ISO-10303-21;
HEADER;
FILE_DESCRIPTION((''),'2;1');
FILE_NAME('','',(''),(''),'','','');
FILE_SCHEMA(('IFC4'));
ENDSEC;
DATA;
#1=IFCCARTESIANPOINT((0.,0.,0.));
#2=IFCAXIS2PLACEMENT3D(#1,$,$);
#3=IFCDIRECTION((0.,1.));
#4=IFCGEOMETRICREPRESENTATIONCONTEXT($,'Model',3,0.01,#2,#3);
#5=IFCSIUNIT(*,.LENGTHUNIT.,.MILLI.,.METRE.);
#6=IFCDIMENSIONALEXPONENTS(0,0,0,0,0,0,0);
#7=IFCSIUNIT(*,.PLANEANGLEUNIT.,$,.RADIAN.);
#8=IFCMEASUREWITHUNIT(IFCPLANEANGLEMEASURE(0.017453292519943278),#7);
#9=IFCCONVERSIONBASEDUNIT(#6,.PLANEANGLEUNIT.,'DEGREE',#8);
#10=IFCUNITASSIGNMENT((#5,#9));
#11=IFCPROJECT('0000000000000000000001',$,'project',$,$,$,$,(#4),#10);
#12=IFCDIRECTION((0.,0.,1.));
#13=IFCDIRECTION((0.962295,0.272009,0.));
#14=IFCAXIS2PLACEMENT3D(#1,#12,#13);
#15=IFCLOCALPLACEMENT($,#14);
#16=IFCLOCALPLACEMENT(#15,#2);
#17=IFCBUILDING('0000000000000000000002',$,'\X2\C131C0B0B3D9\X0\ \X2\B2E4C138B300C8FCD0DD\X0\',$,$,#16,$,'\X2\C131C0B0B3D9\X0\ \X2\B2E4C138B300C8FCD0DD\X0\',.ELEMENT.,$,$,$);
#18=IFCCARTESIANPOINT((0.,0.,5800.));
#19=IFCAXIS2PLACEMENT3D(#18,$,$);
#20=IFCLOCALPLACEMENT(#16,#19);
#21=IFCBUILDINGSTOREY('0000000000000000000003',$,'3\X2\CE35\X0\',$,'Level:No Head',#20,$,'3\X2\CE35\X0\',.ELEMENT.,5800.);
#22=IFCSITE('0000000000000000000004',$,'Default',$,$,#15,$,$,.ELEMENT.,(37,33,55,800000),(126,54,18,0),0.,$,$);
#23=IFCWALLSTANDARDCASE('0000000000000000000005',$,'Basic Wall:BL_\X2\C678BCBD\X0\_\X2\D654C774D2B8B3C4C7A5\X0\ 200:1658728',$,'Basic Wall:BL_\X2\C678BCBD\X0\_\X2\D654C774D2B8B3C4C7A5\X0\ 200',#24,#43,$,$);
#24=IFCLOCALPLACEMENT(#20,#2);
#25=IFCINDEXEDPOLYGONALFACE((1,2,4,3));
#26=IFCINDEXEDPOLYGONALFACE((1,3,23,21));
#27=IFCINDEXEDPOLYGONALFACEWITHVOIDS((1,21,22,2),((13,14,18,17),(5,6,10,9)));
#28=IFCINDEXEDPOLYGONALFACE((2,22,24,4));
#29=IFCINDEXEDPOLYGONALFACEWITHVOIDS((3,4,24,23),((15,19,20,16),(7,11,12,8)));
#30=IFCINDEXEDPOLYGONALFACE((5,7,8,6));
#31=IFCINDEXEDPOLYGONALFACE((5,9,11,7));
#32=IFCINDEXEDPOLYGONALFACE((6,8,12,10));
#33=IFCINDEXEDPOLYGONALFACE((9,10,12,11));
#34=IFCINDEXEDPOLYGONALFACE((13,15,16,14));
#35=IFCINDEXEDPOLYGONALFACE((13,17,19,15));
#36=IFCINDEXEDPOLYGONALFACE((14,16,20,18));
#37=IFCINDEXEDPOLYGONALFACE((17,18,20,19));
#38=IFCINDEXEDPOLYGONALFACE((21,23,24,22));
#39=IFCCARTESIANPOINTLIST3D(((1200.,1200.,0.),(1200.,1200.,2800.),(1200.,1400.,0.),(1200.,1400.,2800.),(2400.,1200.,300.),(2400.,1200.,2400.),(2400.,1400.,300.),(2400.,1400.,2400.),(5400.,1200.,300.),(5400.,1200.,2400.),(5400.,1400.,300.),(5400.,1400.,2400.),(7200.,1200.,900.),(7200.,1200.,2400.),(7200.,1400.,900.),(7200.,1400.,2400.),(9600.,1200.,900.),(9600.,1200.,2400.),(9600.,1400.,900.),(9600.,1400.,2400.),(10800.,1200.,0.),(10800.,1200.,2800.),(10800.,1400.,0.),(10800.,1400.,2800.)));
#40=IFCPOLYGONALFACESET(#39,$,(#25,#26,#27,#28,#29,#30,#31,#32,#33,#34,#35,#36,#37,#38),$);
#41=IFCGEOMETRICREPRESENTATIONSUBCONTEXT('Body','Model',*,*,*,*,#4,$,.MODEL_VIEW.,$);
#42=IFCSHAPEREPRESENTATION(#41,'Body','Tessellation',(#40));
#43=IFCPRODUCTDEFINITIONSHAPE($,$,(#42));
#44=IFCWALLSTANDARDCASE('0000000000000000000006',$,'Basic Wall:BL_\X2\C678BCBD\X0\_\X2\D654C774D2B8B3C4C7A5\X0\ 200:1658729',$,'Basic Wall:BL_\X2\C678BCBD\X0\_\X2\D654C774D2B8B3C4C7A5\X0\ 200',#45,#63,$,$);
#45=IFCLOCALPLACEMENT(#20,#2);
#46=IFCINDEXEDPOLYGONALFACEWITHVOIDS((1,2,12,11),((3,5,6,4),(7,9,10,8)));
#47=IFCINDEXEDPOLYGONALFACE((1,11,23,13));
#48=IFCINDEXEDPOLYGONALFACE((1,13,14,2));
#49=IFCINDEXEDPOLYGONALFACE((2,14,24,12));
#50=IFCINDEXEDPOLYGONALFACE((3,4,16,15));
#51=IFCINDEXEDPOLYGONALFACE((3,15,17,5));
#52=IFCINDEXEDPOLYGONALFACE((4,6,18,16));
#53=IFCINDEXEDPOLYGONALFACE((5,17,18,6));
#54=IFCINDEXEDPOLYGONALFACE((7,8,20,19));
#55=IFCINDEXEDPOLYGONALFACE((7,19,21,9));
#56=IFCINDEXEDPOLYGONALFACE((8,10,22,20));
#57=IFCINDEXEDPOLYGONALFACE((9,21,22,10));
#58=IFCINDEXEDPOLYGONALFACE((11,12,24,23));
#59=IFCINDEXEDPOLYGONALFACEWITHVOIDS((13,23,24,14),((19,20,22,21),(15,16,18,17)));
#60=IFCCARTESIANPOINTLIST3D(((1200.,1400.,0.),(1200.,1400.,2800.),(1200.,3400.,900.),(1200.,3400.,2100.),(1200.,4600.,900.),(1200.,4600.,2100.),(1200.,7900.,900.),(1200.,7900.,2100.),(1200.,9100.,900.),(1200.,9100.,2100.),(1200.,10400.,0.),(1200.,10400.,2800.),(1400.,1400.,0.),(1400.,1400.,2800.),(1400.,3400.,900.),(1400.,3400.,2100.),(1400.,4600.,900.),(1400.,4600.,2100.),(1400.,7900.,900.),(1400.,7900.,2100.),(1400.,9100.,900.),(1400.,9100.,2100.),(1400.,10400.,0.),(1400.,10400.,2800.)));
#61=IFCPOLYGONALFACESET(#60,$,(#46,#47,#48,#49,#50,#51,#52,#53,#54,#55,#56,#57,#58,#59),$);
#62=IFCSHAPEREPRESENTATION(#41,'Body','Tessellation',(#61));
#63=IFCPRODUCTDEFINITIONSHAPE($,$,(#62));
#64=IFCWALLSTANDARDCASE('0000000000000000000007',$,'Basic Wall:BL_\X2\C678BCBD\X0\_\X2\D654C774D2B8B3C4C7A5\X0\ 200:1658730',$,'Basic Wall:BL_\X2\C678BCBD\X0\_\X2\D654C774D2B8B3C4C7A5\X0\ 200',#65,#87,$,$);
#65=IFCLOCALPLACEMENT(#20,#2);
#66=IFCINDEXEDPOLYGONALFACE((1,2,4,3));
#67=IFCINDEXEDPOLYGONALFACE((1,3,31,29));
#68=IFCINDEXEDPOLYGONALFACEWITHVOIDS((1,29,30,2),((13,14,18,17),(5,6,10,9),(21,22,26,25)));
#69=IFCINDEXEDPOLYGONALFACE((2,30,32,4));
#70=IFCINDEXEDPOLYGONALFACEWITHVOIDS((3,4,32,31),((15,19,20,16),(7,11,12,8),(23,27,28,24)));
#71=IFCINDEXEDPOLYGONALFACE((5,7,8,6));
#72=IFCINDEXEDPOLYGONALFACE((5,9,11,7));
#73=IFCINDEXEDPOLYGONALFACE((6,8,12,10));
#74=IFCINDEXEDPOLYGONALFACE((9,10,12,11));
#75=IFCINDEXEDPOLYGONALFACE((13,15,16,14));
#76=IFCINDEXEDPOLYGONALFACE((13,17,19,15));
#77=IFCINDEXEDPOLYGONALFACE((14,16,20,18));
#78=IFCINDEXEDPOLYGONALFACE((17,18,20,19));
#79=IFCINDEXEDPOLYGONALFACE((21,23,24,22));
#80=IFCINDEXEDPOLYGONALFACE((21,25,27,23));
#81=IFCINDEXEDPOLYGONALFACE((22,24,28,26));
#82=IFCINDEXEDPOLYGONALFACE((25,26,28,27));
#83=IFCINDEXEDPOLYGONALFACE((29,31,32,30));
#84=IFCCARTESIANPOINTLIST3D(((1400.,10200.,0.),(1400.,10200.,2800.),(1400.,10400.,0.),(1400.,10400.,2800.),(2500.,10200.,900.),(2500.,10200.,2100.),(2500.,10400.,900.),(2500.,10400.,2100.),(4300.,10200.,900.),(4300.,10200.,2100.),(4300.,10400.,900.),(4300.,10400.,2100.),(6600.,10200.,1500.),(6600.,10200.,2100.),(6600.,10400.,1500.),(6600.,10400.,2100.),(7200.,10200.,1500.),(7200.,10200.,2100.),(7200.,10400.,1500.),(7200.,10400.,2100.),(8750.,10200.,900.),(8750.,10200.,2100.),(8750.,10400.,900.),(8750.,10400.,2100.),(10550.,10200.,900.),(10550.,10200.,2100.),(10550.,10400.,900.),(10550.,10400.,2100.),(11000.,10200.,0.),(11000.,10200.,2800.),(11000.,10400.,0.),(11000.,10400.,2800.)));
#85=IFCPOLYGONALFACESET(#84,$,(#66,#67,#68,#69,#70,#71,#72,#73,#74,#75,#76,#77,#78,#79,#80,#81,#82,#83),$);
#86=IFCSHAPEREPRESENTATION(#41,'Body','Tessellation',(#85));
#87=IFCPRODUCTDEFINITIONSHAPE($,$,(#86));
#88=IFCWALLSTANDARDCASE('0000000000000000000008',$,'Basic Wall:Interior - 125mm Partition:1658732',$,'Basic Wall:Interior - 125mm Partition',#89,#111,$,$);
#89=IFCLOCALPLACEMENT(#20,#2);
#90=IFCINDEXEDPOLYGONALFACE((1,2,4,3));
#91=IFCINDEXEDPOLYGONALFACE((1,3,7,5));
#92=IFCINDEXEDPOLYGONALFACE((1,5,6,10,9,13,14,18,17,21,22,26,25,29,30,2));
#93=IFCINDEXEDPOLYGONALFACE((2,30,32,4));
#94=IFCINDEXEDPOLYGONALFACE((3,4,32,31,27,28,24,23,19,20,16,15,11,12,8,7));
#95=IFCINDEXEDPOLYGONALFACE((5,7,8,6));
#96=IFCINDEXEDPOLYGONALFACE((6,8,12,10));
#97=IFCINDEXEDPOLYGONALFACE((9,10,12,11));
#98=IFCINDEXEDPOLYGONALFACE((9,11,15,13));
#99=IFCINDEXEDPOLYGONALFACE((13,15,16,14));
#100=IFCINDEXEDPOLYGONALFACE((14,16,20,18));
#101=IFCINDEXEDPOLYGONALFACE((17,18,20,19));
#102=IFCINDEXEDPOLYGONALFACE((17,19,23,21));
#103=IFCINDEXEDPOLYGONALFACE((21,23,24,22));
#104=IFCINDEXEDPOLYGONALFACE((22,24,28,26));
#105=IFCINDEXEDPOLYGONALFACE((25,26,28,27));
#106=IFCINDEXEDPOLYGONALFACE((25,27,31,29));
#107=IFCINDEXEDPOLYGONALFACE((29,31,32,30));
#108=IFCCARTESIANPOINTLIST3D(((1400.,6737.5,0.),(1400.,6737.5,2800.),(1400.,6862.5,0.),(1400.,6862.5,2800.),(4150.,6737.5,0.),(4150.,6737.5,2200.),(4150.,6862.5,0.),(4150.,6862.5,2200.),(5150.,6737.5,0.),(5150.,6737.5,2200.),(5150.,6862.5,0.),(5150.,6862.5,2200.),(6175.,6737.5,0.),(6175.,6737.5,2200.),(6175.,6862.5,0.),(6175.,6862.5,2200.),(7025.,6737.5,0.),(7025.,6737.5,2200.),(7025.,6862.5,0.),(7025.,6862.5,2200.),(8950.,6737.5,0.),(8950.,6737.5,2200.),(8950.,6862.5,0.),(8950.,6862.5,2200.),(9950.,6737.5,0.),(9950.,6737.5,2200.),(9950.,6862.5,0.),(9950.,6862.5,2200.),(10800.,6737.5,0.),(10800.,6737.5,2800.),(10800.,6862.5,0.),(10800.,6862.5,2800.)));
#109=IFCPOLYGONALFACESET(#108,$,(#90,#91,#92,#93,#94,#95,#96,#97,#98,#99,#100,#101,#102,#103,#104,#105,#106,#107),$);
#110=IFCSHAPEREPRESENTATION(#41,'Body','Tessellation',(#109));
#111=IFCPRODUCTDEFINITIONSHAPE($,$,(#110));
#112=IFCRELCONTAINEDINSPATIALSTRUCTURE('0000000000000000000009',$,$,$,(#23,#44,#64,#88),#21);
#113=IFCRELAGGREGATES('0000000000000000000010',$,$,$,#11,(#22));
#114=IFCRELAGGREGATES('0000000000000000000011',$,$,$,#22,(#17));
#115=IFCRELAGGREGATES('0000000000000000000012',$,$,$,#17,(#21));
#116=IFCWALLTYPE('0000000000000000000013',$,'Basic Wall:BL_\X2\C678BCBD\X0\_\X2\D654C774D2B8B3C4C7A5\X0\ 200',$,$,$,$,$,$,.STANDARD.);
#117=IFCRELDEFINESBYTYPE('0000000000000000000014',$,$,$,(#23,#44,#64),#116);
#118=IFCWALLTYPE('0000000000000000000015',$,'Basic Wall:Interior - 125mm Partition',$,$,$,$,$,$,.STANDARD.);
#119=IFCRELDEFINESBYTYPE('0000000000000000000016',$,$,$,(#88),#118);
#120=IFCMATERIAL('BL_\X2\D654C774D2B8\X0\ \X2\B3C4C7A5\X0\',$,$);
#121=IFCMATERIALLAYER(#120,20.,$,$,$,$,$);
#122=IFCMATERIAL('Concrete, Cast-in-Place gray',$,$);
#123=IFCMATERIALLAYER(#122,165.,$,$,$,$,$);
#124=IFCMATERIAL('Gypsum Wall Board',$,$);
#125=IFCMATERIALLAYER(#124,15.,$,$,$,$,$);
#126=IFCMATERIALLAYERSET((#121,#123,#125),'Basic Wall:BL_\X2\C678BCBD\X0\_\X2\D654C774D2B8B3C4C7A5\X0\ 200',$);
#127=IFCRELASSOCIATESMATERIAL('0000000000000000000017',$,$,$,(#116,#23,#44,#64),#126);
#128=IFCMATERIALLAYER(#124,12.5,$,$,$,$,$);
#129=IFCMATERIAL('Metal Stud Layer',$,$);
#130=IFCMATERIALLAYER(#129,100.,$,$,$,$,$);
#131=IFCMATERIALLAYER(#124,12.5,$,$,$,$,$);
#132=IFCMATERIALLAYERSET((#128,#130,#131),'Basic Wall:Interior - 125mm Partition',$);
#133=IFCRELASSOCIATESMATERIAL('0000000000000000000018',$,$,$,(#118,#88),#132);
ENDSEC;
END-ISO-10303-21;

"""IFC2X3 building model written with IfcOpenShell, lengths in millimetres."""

from ifc_helpers import new_model, entity, si_unit, converted_unit, direction, frame, frame_2d, origin, place, context, subcontext, project, spatial, rectangle, extrude, material, layer, layer_set, layer_usage, type_object, element, save


model = new_model("IFC2X3")

# Units and contexts
model_context = context("Model", 3, precision=0.01, world=origin(), true_north=direction((0.0, 1.0)))
body_context = subcontext(model_context, "Body", "Model", "MODEL_VIEW")
ifc_project = project(units=[si_unit("LENGTHUNIT", "METRE", prefix="MILLI"), converted_unit("PLANEANGLEUNIT", "DEGREE", entity("IfcPlaneAngleMeasure", 0.017453292519943278), si_unit("PLANEANGLEUNIT", "RADIAN"), dimensions=[0, 0, 0, 0, 0, 0, 0])], contexts=[model_context])

# Site, building, storey
site_placement = place(None, frame((0.0, 0.0, 0.0), z_axis=(0.0, 0.0, 1.0), x_axis=(0.962295, 0.272009, 0.0)))
site = spatial("IfcSite", under=ifc_project, at=site_placement, Name="Default", CompositionType="ELEMENT", RefLatitude=(37, 33, 55, 800000), RefLongitude=(126, 54, 18, 0), RefElevation=0.0)
building_placement = place(site_placement, origin())
building = spatial("IfcBuilding", under=site, at=building_placement, Name="성산동 다세대주택", LongName="성산동 다세대주택", CompositionType="ELEMENT")
storey_placement = place(building_placement, frame((0.0, 0.0, 5800.0)))
storey = spatial("IfcBuildingStorey", under=building, at=storey_placement, Name="3층", ObjectType="Level:No Head", LongName="3층", CompositionType="ELEMENT", Elevation=5800.0)

# Walls, openings
ifc_material_1 = material(Name="BL_화이트 도장")
ifc_layer_1 = layer(ifc_material_1, 20.0)
ifc_material_2 = material(Name="Concrete, Cast-in-Place gray")
ifc_layer_2 = layer(ifc_material_2, 165.0)
ifc_material_3 = material(Name="Gypsum Wall Board")
ifc_layer_3 = layer(ifc_material_3, 15.0)
ifc_layer_set_1 = layer_set([ifc_layer_1, ifc_layer_2, ifc_layer_3], Name="Basic Wall:BL_외벽_화이트도장 200")
ifc_layer_usage_1 = layer_usage(ifc_layer_set_1, "AXIS2", "POSITIVE", -100.0)
wall_type_1 = type_object("IfcWallType", Name="Basic Wall:BL_외벽_화이트도장 200", PredefinedType="STANDARD", material=ifc_layer_set_1)
wall_1_placement = place(storey_placement, frame((1200.0, 1300.0, 0.0)))
wall_1 = element("IfcWallStandardCase", 1, at=wall_1_placement, inside=storey, type_object=wall_type_1, material=ifc_layer_usage_1, Name="Basic Wall:BL_외벽_화이트도장 200:1658728", ObjectType="Basic Wall:BL_외벽_화이트도장 200", context=body_context, shape_type="SweptSolid", body=[
    extrude(rectangle(XDim=9600.0, YDim=200.0, at=frame_2d((4800.0, 0.0), x_axis=(-1.0, 0.0))), origin(), (0.0, 0.0, 1.0), 2800.0),
])
opening_1_placement = place(wall_1_placement, frame((1200.0, -100.0, 300.0)))
element("IfcOpeningElement", 2, at=opening_1_placement, cuts=wall_1, ObjectType="Opening", context=body_context, shape_type="SweptSolid", body=[
    extrude(rectangle(XDim=2100.0, YDim=3000.0, at=frame_2d((1050.0, 1500.0), x_axis=(-1.0, 0.0))), frame((0.0, 0.0, 0.0), z_axis=(0.0, 1.0, 0.0), x_axis=(0.0, 0.0, 1.0)), (0.0, 0.0, 1.0), 200.0),
])
opening_2_placement = place(wall_1_placement, frame((6000.0, -100.0, 900.0)))
element("IfcOpeningElement", 3, at=opening_2_placement, cuts=wall_1, ObjectType="Opening", context=body_context, shape_type="SweptSolid", body=[
    extrude(rectangle(XDim=1500.0, YDim=2400.0, at=frame_2d((750.0, 1200.0), x_axis=(-1.0, 0.0))), frame((0.0, 0.0, 0.0), z_axis=(0.0, 1.0, 0.0), x_axis=(0.0, 0.0, 1.0)), (0.0, 0.0, 1.0), 200.0),
])
ifc_layer_usage_2 = layer_usage(ifc_layer_set_1, "AXIS2", "NEGATIVE", 100.0)
wall_2_placement = place(storey_placement, frame((1300.0, 1400.0, 0.0), z_axis=(0.0, 0.0, 1.0), x_axis=(0.0, 1.0, 0.0)))
wall_2 = element("IfcWallStandardCase", 4, at=wall_2_placement, inside=storey, type_object=wall_type_1, material=ifc_layer_usage_2, Name="Basic Wall:BL_외벽_화이트도장 200:1658729", ObjectType="Basic Wall:BL_외벽_화이트도장 200", context=body_context, shape_type="SweptSolid", body=[
    extrude(rectangle(XDim=9000.0, YDim=200.0, at=frame_2d((4500.0, 0.0), x_axis=(-1.0, 0.0))), origin(), (0.0, 0.0, 1.0), 2800.0),
])
opening_3_placement = place(wall_2_placement, frame((2000.0, -100.0, 900.0)))
element("IfcOpeningElement", 5, at=opening_3_placement, cuts=wall_2, ObjectType="Opening", context=body_context, shape_type="SweptSolid", body=[
    extrude(rectangle(XDim=1200.0, YDim=1200.0, at=frame_2d((600.0, 600.0), x_axis=(-1.0, 0.0))), frame((0.0, 0.0, 0.0), z_axis=(0.0, 1.0, 0.0), x_axis=(0.0, 0.0, 1.0)), (0.0, 0.0, 1.0), 200.0),
])
opening_4_placement = place(wall_2_placement, frame((6500.0, -100.0, 900.0)))
element("IfcOpeningElement", 6, at=opening_4_placement, cuts=wall_2, ObjectType="Opening", context=body_context, shape_type="SweptSolid", body=[
    extrude(rectangle(XDim=1200.0, YDim=1200.0, at=frame_2d((600.0, 600.0), x_axis=(-1.0, 0.0))), frame((0.0, 0.0, 0.0), z_axis=(0.0, 1.0, 0.0), x_axis=(0.0, 0.0, 1.0)), (0.0, 0.0, 1.0), 200.0),
])
ifc_layer_usage_3 = layer_usage(ifc_layer_set_1, "AXIS2", "NEGATIVE", 100.0)
wall_3_placement = place(storey_placement, frame((1400.0, 10300.0, 0.0)))
wall_3 = element("IfcWallStandardCase", 7, at=wall_3_placement, inside=storey, type_object=wall_type_1, material=ifc_layer_usage_3, Name="Basic Wall:BL_외벽_화이트도장 200:1658730", ObjectType="Basic Wall:BL_외벽_화이트도장 200", context=body_context, shape_type="SweptSolid", body=[
    extrude(rectangle(XDim=9600.0, YDim=200.0, at=frame_2d((4800.0, 0.0), x_axis=(-1.0, 0.0))), origin(), (0.0, 0.0, 1.0), 2800.0),
])
opening_5_placement = place(wall_3_placement, frame((1100.0, -100.0, 900.0)))
element("IfcOpeningElement", 8, at=opening_5_placement, cuts=wall_3, ObjectType="Opening", context=body_context, shape_type="SweptSolid", body=[
    extrude(rectangle(XDim=1200.0, YDim=1800.0, at=frame_2d((600.0, 900.0), x_axis=(-1.0, 0.0))), frame((0.0, 0.0, 0.0), z_axis=(0.0, 1.0, 0.0), x_axis=(0.0, 0.0, 1.0)), (0.0, 0.0, 1.0), 200.0),
])
opening_6_placement = place(wall_3_placement, frame((5200.0, -100.0, 1500.0)))
element("IfcOpeningElement", 9, at=opening_6_placement, cuts=wall_3, ObjectType="Opening", context=body_context, shape_type="SweptSolid", body=[
    extrude(rectangle(XDim=600.0, YDim=600.0, at=frame_2d((300.0, 300.0), x_axis=(-1.0, 0.0))), frame((0.0, 0.0, 0.0), z_axis=(0.0, 1.0, 0.0), x_axis=(0.0, 0.0, 1.0)), (0.0, 0.0, 1.0), 200.0),
])
opening_7_placement = place(wall_3_placement, frame((7350.0, -100.0, 900.0)))
element("IfcOpeningElement", 10, at=opening_7_placement, cuts=wall_3, ObjectType="Opening", context=body_context, shape_type="SweptSolid", body=[
    extrude(rectangle(XDim=1200.0, YDim=1800.0, at=frame_2d((600.0, 900.0), x_axis=(-1.0, 0.0))), frame((0.0, 0.0, 0.0), z_axis=(0.0, 1.0, 0.0), x_axis=(0.0, 0.0, 1.0)), (0.0, 0.0, 1.0), 200.0),
])
ifc_layer_4 = layer(ifc_material_3, 12.5)
ifc_material_4 = material(Name="Metal Stud Layer")
ifc_layer_5 = layer(ifc_material_4, 100.0)
ifc_layer_6 = layer(ifc_material_3, 12.5)
ifc_layer_set_2 = layer_set([ifc_layer_4, ifc_layer_5, ifc_layer_6], Name="Basic Wall:Interior - 125mm Partition")
ifc_layer_usage_4 = layer_usage(ifc_layer_set_2, "AXIS2", "NEGATIVE", 62.5)
wall_type_2 = type_object("IfcWallType", Name="Basic Wall:Interior - 125mm Partition", PredefinedType="STANDARD", material=ifc_layer_set_2)
wall_4_placement = place(storey_placement, frame((1400.0, 6800.0, 0.0)))
wall_4 = element("IfcWallStandardCase", 11, at=wall_4_placement, inside=storey, type_object=wall_type_2, material=ifc_layer_usage_4, Name="Basic Wall:Interior - 125mm Partition:1658732", ObjectType="Basic Wall:Interior - 125mm Partition", context=body_context, shape_type="SweptSolid", body=[
    extrude(rectangle(XDim=9400.0, YDim=125.0, at=frame_2d((4700.0, 0.0), x_axis=(1.0, 0.0))), origin(), (0.0, 0.0, 1.0), 2800.0),
])
opening_8_placement = place(wall_4_placement, frame((7550.0, -62.5, 0.0)))
element("IfcOpeningElement", 12, at=opening_8_placement, cuts=wall_4, ObjectType="Opening", context=body_context, shape_type="SweptSolid", body=[
    extrude(rectangle(XDim=2200.0, YDim=1000.0, at=frame_2d((1100.0, 500.0), x_axis=(1.0, 0.0))), frame((0.0, 0.0, 0.0), z_axis=(0.0, 1.0, 0.0), x_axis=(0.0, 0.0, 1.0)), (0.0, 0.0, 1.0), 125.0),
])
opening_9_placement = place(wall_4_placement, frame((4775.0, -62.5, 0.0)))
element("IfcOpeningElement", 13, at=opening_9_placement, cuts=wall_4, ObjectType="Opening", context=body_context, shape_type="SweptSolid", body=[
    extrude(rectangle(XDim=2200.0, YDim=850.0, at=frame_2d((1100.0, 425.0), x_axis=(1.0, 0.0))), frame((0.0, 0.0, 0.0), z_axis=(0.0, 1.0, 0.0), x_axis=(0.0, 0.0, 1.0)), (0.0, 0.0, 1.0), 125.0),
])
opening_10_placement = place(wall_4_placement, frame((2750.0, -62.5, 0.0)))
element("IfcOpeningElement", 14, at=opening_10_placement, cuts=wall_4, ObjectType="Opening", context=body_context, shape_type="SweptSolid", body=[
    extrude(rectangle(XDim=2200.0, YDim=1000.0, at=frame_2d((1100.0, 500.0), x_axis=(1.0, 0.0))), frame((0.0, 0.0, 0.0), z_axis=(0.0, 1.0, 0.0), x_axis=(0.0, 0.0, 1.0)), (0.0, 0.0, 1.0), 125.0),
])

save(model, "model.ifc")
